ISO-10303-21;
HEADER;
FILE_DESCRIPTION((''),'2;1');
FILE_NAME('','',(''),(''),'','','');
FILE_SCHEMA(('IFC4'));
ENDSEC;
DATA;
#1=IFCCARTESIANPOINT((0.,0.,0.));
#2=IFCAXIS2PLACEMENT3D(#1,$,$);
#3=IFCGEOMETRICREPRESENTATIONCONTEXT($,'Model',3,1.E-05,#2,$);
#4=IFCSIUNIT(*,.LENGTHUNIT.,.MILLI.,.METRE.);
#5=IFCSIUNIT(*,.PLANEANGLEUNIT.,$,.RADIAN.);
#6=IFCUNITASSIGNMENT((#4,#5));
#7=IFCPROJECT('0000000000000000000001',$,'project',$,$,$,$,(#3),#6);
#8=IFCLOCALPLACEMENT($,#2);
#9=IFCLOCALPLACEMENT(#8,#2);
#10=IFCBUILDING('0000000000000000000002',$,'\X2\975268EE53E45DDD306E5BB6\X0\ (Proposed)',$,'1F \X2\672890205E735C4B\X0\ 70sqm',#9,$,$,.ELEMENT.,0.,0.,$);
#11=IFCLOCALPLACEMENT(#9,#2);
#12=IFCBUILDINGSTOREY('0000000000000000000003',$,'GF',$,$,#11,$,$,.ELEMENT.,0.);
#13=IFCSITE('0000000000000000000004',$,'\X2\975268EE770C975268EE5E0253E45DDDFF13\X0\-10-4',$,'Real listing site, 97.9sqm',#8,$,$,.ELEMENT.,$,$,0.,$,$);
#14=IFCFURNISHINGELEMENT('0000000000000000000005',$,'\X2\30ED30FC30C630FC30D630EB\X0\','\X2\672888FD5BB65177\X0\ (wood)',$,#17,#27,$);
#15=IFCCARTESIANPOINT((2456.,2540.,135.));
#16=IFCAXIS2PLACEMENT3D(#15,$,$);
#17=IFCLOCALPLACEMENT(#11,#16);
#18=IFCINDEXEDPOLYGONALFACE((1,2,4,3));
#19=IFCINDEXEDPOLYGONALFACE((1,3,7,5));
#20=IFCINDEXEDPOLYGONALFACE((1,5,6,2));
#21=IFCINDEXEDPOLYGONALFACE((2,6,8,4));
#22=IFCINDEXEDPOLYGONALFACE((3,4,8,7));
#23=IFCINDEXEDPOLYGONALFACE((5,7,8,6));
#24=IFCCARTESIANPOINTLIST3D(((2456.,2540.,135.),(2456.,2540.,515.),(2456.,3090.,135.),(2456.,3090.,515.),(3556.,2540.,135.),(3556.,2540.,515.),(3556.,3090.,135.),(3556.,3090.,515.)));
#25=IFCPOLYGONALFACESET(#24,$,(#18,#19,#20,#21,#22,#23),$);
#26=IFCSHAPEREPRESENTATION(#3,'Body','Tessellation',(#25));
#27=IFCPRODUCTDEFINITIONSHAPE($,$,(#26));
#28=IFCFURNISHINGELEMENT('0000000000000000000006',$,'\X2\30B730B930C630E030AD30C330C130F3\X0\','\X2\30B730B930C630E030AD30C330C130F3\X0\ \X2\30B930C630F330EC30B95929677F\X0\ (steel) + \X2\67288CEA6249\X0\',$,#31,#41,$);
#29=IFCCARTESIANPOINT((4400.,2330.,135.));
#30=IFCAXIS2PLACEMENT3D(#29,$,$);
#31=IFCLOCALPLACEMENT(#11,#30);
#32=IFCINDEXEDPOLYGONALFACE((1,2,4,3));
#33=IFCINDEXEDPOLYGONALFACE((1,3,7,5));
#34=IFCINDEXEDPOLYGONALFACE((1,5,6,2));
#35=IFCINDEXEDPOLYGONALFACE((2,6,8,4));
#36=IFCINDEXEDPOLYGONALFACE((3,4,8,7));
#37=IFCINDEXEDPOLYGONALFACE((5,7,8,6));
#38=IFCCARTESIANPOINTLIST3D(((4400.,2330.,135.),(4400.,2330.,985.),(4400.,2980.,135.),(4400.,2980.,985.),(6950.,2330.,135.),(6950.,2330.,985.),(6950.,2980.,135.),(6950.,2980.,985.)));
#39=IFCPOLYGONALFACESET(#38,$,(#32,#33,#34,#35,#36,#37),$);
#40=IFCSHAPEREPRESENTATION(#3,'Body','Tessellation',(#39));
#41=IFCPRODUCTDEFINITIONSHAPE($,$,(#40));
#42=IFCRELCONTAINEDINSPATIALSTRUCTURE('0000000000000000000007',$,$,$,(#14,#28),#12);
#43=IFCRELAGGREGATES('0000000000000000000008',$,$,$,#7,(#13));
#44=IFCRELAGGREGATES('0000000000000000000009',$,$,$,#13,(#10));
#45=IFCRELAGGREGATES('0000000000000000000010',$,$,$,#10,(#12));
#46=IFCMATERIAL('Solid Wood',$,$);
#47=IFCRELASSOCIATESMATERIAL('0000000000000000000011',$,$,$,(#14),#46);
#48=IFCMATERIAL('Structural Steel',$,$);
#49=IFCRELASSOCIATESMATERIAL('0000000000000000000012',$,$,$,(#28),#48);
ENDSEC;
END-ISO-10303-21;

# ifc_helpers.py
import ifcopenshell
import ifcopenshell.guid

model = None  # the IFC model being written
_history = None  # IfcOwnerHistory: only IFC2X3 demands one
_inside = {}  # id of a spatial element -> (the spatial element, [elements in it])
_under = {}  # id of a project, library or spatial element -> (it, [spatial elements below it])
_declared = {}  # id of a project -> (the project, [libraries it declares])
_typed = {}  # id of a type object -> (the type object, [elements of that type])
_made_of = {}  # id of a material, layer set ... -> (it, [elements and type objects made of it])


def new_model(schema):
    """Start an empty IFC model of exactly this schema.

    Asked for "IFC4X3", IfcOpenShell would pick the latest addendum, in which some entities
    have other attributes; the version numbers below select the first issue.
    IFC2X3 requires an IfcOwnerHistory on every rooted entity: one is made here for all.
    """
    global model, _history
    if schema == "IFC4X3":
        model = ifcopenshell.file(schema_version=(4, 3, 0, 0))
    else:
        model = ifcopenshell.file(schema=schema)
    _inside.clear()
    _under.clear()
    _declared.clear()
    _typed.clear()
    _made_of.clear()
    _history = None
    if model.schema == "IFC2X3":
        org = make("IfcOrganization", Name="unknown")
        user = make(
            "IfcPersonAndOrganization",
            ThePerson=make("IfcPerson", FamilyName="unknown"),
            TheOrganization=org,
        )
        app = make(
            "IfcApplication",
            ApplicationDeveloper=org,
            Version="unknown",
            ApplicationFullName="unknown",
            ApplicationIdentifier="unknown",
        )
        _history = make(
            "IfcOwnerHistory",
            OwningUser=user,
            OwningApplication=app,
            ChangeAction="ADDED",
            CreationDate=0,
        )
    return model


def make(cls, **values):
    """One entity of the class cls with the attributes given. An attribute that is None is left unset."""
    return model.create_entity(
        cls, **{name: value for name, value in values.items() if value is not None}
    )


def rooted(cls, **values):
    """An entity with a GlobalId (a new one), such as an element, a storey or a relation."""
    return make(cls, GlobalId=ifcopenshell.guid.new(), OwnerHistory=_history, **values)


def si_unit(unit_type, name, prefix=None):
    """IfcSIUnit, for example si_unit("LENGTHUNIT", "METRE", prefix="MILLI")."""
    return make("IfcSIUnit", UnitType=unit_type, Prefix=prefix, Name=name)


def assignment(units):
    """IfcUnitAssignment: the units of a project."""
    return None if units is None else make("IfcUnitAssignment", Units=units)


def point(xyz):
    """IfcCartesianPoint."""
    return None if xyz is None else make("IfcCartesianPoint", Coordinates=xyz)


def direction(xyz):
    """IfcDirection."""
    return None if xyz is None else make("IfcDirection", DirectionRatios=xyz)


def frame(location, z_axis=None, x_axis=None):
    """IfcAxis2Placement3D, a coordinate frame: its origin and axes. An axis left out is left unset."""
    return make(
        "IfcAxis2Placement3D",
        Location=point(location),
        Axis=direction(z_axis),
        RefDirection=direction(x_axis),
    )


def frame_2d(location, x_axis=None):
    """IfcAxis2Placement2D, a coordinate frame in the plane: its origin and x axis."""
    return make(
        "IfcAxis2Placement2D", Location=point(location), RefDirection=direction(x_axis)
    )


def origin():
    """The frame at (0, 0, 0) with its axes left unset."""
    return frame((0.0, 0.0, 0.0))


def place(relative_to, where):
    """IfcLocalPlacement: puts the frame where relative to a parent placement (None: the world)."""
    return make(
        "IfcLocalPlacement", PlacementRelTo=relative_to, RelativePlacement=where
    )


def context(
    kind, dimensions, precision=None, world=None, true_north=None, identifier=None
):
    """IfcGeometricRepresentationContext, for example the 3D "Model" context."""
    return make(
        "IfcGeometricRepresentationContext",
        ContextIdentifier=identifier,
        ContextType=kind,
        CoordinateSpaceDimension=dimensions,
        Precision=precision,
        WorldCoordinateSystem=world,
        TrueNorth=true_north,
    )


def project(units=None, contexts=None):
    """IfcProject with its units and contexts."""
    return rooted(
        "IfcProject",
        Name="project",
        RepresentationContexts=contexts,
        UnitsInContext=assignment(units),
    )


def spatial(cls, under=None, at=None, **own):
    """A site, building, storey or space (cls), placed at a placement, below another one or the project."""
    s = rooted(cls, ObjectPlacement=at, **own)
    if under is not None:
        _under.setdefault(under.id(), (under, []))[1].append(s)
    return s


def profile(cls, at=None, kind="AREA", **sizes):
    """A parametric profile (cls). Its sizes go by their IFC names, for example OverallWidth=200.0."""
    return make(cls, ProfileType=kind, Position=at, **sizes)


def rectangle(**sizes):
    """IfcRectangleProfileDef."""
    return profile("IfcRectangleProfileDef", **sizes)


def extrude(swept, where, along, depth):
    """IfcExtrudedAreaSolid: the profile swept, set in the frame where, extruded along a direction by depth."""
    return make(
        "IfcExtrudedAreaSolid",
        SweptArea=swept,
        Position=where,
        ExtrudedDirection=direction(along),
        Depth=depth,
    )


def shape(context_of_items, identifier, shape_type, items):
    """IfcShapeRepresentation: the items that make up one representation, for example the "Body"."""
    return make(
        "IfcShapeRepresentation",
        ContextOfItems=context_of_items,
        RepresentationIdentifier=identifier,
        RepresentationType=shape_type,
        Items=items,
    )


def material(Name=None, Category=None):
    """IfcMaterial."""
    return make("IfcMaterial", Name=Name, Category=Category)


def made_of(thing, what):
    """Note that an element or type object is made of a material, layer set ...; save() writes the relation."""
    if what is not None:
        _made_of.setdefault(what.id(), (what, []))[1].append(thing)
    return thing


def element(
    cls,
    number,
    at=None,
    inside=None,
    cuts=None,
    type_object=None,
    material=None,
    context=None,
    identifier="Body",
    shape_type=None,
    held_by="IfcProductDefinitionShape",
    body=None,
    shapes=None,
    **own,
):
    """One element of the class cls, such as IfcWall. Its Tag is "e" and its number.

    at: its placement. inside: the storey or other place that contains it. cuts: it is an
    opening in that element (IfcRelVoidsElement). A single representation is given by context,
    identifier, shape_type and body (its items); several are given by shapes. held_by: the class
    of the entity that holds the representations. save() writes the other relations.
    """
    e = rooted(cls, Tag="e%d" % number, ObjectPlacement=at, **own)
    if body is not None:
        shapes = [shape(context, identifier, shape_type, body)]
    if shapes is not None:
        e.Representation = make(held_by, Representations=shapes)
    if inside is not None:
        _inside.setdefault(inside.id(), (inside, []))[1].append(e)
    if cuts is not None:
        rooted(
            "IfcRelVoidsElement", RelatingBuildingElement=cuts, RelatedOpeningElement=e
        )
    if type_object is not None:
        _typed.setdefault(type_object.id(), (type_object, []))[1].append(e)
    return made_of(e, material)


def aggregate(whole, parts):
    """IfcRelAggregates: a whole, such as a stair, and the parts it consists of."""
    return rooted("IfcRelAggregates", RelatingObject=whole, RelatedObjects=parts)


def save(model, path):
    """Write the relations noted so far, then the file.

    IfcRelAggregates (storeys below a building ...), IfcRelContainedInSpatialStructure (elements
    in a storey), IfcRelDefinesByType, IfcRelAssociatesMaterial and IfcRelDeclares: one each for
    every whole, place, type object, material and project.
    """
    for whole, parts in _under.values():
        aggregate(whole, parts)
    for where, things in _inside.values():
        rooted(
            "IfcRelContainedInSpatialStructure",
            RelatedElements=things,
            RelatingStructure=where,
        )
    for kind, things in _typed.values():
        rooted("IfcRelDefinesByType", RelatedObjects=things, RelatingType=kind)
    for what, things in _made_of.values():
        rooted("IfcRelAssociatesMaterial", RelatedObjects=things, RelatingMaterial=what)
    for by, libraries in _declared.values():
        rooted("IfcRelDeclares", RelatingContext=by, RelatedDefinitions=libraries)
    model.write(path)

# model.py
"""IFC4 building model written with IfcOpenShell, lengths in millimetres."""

from ifc_helpers import new_model, si_unit, frame, frame_2d, origin, place, context, project, spatial, rectangle, extrude, material, element, save


model = new_model("IFC4")

# Units and contexts
model_context = context("Model", 3, precision=1e-05, world=origin())
ifc_project = project(units=[si_unit("LENGTHUNIT", "METRE", prefix="MILLI"), si_unit("PLANEANGLEUNIT", "RADIAN")], contexts=[model_context])

# Site, building, storey
site_placement = place(None, origin())
site = spatial("IfcSite", under=ifc_project, at=site_placement, Name="青森県青森市古川３-10-4", ObjectType="Real listing site, 97.9sqm", CompositionType="ELEMENT", RefElevation=0.0)
building_placement = place(site_placement, origin())
building = spatial("IfcBuilding", under=site, at=building_placement, Name="青森古川の家 (Proposed)", ObjectType="1F 木造平屋 70sqm", CompositionType="ELEMENT", ElevationOfRefHeight=0.0, ElevationOfTerrain=0.0)
storey_placement = place(building_placement, origin())
storey = spatial("IfcBuildingStorey", under=building, at=storey_placement, Name="GF", CompositionType="ELEMENT", Elevation=0.0)

# Shared definitions
ifc_material_1 = material(Name="Solid Wood")

# Furnishing elements
furnishing_1_placement = place(storey_placement, frame((2456.0, 2540.0, 135.0)))
element("IfcFurnishingElement", 1, at=furnishing_1_placement, inside=storey, material=ifc_material_1, Name="ローテーブル", Description="木製家具 (wood)", context=model_context, shape_type="SweptSolid", body=[
    extrude(rectangle(XDim=1100.0, YDim=550.0, at=frame_2d((550.0, 275.0))), frame((2456.0, 2540.0, 135.0)), (0.0, 0.0, 1.0), 380.0),
])
ifc_material_2 = material(Name="Structural Steel")
furnishing_2_placement = place(storey_placement, frame((4400.0, 2330.0, 135.0)))
element("IfcFurnishingElement", 2, at=furnishing_2_placement, inside=storey, material=ifc_material_2, Name="システムキッチン", Description="システムキッチン ステンレス天板 (steel) + 木質扉", context=model_context, shape_type="SweptSolid", body=[
    extrude(rectangle(XDim=2550.0, YDim=650.0, at=frame_2d((1275.0, 325.0))), frame((4400.0, 2330.0, 135.0)), (0.0, 0.0, 1.0), 850.0),
])

save(model, "model.ifc")
